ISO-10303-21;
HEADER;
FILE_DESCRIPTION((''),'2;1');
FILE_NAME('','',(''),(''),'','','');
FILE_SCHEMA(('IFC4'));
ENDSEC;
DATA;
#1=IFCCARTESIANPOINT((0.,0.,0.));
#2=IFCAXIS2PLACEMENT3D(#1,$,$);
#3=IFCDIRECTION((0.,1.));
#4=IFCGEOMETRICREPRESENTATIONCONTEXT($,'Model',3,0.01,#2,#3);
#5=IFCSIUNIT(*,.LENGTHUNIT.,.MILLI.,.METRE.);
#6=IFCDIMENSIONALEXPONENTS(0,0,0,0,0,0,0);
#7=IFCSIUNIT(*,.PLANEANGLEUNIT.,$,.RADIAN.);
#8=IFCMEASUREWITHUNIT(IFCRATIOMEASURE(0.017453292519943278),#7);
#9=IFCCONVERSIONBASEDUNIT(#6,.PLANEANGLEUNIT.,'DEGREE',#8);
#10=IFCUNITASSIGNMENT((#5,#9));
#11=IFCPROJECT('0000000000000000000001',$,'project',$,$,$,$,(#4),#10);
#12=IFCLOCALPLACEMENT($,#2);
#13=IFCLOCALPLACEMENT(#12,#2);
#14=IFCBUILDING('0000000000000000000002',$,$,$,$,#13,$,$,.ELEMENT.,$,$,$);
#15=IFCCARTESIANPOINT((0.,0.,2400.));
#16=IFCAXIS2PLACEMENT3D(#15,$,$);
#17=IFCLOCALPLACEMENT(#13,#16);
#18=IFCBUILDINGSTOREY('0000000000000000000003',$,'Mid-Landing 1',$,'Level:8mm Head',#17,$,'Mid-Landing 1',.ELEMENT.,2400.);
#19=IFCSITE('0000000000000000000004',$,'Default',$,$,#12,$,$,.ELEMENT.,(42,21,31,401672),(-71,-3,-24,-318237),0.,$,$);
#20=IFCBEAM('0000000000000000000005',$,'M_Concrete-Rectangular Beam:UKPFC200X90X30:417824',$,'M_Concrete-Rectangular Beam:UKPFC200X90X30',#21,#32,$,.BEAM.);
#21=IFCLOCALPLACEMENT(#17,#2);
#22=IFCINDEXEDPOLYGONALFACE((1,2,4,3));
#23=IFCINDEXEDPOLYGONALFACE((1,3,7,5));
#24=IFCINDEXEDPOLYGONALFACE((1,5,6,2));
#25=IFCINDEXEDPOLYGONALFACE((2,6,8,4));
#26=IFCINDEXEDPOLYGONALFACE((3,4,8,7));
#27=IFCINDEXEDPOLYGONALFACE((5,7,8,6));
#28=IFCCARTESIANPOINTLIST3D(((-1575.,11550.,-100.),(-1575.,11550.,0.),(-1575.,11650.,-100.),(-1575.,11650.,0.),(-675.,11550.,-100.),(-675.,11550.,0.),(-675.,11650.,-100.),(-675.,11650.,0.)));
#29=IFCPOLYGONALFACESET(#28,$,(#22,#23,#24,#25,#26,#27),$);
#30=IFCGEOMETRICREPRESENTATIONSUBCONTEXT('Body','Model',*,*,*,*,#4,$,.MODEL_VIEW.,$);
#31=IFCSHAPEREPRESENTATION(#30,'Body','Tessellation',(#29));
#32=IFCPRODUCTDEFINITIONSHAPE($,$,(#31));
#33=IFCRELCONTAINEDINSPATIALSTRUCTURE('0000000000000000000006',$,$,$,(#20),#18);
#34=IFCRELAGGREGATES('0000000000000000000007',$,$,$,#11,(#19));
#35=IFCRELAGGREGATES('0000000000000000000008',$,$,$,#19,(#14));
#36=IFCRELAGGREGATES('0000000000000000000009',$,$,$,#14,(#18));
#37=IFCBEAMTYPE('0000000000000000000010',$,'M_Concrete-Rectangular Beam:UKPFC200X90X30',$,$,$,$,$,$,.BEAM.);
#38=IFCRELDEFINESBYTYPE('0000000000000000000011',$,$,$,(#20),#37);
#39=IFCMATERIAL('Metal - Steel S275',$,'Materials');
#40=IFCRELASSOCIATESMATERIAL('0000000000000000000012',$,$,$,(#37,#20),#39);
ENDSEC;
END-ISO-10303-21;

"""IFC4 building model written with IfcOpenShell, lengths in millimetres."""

from ifc_helpers import new_model, entity, si_unit, converted_unit, direction, frame, origin, place, context, subcontext, project, spatial, indexed_curve, outline, extrude, source, transform, mapped, material, type_object, type_shapes, element, save


model = new_model("IFC4")

# Units and contexts
model_context = context("Model", 3, precision=0.01, world=origin(), true_north=direction((0.0, 1.0)))
body_context = subcontext(model_context, "Body", "Model", "MODEL_VIEW")
ifc_project = project(units=[si_unit("LENGTHUNIT", "METRE", prefix="MILLI"), converted_unit("PLANEANGLEUNIT", "DEGREE", entity("IfcRatioMeasure", 0.017453292519943278), si_unit("PLANEANGLEUNIT", "RADIAN"), dimensions=[0, 0, 0, 0, 0, 0, 0])], contexts=[model_context])

# Site, building, storey
site_placement = place(None, origin())
site = spatial("IfcSite", under=ifc_project, at=site_placement, Name="Default", CompositionType="ELEMENT", RefLatitude=(42, 21, 31, 401672), RefLongitude=(-71, -3, -24, -318237), RefElevation=0.0)
building_placement = place(site_placement, origin())
building = spatial("IfcBuilding", under=site, at=building_placement, CompositionType="ELEMENT")
storey_placement = place(building_placement, frame((0.0, 0.0, 2400.0)))
storey = spatial("IfcBuildingStorey", under=building, at=storey_placement, Name="Mid-Landing 1", ObjectType="Level:8mm Head", LongName="Mid-Landing 1", CompositionType="ELEMENT", Elevation=2400.0)

# Beam
ifc_material = material(Name="Metal - Steel S275", Category="Materials")
beam_type_1 = type_object("IfcBeamType", Name="M_Concrete-Rectangular Beam:UKPFC200X90X30", PredefinedType="BEAM", material=ifc_material)
shared_shape_1 = source(origin(), body_context, "Body", "SweptSolid", [
    extrude(outline(indexed_curve([(-50.0, -50.0), (50.0, -50.0), (50.0, 50.0), (-50.0, 50.0), (-50.0, -50.0)], self_intersect=False)), frame((-1575.0, 11600.0, 2350.0), z_axis=(1.0, 0.0, 0.0), x_axis=(0.0, 0.0, -1.0)), (0.0, 0.0, 1.0), 900.0),
])
type_shapes(beam_type_1, [shared_shape_1])
beam_1_placement = place(storey_placement, frame((0.0, 0.0, -2400.0)))
element("IfcBeam", 1, at=beam_1_placement, inside=storey, type_object=beam_type_1, material=ifc_material, Name="M_Concrete-Rectangular Beam:UKPFC200X90X30:417824", ObjectType="M_Concrete-Rectangular Beam:UKPFC200X90X30", PredefinedType="BEAM", context=body_context, shape_type="MappedRepresentation", body=[
    mapped(shared_shape_1, transform((0.0, 0.0, 0.0), scale=1.0)),
])

save(model, "model.ifc")
